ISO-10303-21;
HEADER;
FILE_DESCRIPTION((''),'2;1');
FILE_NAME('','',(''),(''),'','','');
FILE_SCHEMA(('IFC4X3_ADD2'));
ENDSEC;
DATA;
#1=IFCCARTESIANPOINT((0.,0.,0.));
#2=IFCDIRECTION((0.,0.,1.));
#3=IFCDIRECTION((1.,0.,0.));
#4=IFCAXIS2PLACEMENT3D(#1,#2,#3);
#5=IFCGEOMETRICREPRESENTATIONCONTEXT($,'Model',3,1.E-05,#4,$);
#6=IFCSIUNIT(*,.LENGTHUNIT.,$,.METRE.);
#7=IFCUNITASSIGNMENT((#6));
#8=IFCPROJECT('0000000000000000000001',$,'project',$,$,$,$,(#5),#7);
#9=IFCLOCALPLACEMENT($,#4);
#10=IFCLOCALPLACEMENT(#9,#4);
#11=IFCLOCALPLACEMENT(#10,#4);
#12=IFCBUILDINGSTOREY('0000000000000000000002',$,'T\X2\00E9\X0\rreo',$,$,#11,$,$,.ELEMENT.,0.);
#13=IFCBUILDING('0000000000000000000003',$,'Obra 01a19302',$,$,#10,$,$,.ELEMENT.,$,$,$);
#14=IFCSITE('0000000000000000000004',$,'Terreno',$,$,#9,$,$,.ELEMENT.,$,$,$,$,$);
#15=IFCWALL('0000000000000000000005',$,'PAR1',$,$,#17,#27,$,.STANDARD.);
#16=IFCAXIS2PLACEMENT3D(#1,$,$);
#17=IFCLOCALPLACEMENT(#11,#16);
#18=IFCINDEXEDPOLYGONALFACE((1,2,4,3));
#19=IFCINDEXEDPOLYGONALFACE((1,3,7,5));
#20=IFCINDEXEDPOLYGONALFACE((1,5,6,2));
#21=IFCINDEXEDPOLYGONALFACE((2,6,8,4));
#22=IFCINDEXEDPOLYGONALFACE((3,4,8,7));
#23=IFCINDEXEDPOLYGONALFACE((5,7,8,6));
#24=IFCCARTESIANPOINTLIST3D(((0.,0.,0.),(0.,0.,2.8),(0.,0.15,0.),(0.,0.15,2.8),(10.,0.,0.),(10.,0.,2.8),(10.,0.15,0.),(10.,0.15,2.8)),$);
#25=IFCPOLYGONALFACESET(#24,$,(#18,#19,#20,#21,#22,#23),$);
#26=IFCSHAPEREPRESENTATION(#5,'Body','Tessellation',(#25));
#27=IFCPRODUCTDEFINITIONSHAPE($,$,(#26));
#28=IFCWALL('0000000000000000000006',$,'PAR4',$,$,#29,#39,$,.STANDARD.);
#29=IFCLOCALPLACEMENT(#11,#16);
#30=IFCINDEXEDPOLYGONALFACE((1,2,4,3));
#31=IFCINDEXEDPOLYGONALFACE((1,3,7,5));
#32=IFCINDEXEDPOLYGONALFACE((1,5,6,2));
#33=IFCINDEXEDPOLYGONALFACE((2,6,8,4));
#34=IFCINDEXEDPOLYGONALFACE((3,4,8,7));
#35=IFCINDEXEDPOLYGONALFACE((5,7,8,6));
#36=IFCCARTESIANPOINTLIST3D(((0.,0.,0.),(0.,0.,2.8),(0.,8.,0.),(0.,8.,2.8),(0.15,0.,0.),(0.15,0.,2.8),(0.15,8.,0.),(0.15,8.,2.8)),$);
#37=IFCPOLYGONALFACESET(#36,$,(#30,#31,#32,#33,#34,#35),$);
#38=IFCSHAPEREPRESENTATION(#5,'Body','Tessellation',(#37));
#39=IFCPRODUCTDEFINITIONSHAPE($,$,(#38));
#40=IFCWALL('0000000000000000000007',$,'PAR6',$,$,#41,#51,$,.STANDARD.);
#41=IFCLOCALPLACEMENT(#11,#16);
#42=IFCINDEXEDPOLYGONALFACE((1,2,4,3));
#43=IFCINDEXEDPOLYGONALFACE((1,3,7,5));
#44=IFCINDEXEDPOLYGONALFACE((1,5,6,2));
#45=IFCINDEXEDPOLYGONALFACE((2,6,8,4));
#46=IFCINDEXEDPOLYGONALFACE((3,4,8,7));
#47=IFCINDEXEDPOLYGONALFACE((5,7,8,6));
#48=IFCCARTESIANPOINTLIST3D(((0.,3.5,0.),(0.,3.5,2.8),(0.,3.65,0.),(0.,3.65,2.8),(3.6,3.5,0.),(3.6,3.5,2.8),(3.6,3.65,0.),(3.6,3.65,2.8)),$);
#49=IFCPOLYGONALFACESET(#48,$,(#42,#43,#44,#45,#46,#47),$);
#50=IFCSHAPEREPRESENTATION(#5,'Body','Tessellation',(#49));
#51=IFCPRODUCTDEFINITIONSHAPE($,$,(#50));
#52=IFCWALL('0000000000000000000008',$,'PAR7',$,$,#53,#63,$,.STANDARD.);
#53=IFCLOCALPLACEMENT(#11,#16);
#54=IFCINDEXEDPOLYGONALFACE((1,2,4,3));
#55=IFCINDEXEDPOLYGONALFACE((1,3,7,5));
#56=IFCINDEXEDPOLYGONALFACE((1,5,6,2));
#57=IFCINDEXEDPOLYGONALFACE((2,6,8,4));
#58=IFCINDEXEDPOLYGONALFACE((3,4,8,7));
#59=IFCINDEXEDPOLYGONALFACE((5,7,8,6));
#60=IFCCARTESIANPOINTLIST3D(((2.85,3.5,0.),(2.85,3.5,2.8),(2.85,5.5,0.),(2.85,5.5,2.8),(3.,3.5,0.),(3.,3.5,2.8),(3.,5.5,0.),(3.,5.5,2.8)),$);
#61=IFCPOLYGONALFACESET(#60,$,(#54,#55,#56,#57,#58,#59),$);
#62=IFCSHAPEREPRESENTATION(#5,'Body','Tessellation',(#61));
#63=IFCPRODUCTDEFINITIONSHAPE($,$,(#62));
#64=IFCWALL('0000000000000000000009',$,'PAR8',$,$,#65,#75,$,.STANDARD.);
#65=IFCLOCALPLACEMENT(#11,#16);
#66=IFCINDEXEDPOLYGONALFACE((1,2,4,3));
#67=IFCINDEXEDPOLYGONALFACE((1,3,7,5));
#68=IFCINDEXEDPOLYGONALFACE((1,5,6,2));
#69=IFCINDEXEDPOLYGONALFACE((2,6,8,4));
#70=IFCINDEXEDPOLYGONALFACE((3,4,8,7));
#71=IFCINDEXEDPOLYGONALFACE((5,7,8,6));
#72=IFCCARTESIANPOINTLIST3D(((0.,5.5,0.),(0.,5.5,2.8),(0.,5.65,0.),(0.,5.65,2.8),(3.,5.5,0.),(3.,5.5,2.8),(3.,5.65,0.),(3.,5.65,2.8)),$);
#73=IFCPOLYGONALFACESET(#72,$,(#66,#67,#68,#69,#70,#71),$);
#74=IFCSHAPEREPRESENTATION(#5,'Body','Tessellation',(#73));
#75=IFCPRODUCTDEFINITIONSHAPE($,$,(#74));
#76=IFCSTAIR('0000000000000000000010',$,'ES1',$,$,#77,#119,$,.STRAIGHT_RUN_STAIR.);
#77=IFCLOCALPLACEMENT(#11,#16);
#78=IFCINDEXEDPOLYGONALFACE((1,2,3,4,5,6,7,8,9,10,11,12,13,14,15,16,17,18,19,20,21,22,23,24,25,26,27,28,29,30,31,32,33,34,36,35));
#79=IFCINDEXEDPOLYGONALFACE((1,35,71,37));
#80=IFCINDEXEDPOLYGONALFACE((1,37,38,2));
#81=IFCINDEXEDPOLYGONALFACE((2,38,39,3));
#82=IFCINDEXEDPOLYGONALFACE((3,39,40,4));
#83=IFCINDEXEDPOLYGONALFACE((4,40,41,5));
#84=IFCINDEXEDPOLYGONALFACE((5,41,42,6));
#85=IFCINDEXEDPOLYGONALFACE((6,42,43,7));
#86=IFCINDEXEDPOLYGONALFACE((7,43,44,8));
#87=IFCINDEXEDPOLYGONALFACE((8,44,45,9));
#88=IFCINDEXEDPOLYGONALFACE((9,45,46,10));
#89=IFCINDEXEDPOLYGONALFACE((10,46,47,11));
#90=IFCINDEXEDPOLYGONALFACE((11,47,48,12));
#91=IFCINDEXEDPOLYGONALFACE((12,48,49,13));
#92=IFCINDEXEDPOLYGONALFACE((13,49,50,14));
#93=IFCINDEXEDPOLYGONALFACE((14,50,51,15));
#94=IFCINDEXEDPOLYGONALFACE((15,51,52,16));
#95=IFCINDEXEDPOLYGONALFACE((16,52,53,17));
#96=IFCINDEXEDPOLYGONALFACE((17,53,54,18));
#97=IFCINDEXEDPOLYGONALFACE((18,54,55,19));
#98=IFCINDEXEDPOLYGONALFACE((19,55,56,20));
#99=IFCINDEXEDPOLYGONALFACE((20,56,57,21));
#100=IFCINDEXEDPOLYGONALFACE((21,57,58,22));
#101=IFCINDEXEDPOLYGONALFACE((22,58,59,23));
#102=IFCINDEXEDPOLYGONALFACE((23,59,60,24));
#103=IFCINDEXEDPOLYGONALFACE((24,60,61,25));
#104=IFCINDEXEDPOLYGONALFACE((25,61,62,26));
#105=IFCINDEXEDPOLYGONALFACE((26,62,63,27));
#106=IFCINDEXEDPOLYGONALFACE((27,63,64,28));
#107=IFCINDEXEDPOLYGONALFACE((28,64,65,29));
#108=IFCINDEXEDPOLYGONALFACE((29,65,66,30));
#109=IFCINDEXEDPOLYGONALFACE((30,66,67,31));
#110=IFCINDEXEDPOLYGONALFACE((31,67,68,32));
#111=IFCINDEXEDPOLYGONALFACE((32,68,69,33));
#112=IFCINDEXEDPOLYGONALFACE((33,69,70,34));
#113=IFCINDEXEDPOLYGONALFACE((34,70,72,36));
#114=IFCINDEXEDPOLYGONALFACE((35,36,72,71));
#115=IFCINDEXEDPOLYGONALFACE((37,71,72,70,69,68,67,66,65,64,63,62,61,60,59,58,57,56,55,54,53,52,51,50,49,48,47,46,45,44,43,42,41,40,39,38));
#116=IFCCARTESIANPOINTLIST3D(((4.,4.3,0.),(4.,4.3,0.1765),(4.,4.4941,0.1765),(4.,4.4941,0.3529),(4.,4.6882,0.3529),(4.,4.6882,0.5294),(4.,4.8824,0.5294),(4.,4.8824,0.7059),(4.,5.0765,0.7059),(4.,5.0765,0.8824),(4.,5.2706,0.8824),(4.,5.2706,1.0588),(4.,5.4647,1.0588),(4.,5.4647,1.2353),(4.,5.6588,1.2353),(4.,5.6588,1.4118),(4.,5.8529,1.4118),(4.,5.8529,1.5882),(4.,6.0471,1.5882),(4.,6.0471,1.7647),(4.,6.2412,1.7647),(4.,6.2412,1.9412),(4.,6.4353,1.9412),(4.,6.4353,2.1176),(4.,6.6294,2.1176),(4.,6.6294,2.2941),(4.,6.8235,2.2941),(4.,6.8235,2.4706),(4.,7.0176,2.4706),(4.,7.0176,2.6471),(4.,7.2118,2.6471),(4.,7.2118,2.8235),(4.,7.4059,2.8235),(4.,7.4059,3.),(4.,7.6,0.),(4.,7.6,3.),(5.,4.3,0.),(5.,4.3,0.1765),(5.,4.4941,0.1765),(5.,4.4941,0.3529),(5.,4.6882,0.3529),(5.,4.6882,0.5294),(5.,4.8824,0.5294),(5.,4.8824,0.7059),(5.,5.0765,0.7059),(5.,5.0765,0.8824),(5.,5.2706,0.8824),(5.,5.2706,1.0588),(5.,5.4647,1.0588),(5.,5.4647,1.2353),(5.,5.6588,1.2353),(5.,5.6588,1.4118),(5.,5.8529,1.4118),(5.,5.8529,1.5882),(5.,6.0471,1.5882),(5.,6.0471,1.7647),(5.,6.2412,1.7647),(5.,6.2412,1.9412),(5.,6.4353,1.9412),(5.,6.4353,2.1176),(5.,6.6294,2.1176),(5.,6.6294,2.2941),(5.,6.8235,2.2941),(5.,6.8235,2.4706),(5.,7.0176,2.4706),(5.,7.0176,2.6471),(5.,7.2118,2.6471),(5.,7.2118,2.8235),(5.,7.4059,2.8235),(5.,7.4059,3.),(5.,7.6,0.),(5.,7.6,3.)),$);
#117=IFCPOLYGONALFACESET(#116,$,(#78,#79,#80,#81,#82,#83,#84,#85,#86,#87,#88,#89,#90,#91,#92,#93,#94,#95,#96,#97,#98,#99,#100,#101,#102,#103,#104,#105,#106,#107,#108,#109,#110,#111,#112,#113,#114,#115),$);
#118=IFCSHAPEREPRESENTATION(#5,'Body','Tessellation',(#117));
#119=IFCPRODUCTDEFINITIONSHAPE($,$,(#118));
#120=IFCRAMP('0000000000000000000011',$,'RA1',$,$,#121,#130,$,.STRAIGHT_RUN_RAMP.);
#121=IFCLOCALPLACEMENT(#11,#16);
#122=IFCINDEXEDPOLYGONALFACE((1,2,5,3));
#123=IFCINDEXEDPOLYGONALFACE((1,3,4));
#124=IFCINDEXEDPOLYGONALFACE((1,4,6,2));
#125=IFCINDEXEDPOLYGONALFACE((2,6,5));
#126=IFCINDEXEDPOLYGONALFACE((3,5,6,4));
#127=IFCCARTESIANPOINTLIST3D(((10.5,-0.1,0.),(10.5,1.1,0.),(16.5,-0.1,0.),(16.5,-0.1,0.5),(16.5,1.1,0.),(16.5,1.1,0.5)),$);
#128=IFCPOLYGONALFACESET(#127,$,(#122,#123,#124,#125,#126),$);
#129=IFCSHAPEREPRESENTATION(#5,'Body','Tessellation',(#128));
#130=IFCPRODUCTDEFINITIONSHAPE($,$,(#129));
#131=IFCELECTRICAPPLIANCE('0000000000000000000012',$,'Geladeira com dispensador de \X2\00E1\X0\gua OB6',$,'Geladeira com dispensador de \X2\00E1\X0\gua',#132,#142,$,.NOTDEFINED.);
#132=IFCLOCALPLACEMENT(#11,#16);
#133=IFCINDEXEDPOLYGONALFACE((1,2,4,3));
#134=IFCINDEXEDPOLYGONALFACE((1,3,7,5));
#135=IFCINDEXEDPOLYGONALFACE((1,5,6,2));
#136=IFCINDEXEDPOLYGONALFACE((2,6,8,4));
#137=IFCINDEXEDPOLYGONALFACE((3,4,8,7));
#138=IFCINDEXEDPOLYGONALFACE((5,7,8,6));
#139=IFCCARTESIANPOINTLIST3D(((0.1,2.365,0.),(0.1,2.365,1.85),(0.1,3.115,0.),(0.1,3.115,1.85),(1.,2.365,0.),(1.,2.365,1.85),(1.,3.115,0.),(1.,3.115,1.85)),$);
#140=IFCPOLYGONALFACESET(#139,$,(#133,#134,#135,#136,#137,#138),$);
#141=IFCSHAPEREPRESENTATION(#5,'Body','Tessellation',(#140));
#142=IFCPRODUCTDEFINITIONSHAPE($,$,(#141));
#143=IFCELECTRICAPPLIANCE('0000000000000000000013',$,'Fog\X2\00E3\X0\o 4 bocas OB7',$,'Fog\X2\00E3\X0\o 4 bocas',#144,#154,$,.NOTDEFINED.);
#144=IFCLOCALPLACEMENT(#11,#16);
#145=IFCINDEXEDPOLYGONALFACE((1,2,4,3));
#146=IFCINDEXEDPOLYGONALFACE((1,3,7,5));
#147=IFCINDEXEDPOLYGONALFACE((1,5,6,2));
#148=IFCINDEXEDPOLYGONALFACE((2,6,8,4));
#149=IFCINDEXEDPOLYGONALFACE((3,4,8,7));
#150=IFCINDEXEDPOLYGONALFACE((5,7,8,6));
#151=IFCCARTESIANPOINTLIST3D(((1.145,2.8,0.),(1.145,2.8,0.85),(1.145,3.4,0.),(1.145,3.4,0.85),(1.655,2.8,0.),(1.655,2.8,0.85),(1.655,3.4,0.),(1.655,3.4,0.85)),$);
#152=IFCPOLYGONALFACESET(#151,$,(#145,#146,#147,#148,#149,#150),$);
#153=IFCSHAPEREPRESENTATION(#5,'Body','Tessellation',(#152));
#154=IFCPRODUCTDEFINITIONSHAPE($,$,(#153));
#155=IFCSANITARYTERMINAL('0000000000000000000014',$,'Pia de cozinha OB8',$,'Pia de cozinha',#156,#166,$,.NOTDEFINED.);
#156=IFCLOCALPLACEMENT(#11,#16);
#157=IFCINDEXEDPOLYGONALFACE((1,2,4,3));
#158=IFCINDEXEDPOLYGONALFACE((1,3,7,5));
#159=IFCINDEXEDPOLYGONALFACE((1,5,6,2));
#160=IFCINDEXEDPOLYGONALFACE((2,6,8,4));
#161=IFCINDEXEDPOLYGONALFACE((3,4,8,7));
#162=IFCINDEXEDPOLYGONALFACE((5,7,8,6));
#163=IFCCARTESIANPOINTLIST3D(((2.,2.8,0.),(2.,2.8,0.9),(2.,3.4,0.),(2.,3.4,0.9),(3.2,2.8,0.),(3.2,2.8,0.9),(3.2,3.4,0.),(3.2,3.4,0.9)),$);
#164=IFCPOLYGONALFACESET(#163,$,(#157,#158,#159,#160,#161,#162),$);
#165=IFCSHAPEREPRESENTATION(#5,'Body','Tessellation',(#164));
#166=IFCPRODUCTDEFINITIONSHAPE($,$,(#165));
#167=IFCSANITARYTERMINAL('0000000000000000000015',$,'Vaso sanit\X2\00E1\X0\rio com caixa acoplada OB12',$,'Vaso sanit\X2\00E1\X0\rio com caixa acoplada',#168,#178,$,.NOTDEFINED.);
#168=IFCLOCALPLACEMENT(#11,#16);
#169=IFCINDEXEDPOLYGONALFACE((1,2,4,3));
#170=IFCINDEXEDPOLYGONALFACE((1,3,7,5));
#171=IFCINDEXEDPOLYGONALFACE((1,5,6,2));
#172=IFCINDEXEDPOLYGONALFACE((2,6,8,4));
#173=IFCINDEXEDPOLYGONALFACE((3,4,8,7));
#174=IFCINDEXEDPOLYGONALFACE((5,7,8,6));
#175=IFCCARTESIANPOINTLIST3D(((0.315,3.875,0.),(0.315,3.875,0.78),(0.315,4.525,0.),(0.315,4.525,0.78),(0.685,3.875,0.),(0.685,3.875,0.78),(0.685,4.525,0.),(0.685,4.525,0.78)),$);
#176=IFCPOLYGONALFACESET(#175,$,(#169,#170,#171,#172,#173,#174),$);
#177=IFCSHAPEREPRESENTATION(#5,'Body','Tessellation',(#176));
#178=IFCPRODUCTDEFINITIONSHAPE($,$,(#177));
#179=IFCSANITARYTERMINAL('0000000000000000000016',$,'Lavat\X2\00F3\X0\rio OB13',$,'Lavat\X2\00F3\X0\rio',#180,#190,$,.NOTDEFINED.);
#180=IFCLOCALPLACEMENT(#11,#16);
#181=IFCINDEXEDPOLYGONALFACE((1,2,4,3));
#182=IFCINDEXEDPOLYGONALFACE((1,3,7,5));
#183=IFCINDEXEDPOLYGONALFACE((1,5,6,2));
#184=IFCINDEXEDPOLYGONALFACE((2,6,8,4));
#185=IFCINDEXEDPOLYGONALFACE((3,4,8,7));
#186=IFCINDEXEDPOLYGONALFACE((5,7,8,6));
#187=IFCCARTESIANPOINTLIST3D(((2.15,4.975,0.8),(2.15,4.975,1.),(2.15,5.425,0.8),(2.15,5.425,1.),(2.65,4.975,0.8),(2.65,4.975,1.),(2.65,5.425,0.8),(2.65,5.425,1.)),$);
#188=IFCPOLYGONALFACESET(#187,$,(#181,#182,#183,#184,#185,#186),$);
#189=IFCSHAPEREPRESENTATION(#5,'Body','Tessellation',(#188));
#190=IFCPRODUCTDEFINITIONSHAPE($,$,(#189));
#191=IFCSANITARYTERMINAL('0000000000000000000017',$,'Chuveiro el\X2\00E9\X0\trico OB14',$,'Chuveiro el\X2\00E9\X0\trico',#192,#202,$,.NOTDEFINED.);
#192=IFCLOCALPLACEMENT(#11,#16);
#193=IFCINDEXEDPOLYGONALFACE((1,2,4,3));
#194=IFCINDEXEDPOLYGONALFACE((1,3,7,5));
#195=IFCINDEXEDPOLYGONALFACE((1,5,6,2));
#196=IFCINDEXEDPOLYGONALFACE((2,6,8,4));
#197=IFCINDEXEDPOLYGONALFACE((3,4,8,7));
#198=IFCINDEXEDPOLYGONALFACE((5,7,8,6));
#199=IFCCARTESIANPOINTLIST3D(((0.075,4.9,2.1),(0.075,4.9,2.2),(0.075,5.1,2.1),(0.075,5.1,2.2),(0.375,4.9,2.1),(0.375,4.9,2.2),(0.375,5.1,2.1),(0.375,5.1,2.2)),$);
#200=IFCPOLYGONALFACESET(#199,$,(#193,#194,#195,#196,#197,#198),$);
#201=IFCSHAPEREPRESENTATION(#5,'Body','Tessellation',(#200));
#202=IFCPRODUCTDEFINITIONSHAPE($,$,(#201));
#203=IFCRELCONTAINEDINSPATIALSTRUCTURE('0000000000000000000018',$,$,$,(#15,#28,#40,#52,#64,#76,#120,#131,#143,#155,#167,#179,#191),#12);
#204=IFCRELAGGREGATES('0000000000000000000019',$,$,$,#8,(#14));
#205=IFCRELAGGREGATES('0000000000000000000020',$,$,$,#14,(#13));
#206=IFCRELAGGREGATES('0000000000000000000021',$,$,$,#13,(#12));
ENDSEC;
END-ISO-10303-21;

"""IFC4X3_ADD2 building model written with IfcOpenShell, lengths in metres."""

from ifc_helpers import new_model, si_unit, frame, frame_2d, origin_with_axes, place, context, project, spatial, polyline, rectangle, outline, extrude, element, save


model = new_model("IFC4X3_ADD2")

# Units and contexts
model_context = context("Model", 3, precision=1e-05, world=origin_with_axes())
ifc_project = project(units=[si_unit("LENGTHUNIT", "METRE")], contexts=[model_context])

# Site, building, storey
site_placement = place(None, origin_with_axes())
site = spatial("IfcSite", under=ifc_project, at=site_placement, Name="Terreno", CompositionType="ELEMENT")
building_placement = place(site_placement, origin_with_axes())
building = spatial("IfcBuilding", under=site, at=building_placement, Name="Obra 01a19302", CompositionType="ELEMENT")
storey_placement = place(building_placement, origin_with_axes())
storey = spatial("IfcBuildingStorey", under=building, at=storey_placement, Name="Térreo", CompositionType="ELEMENT", Elevation=0.0)

# Walls
wall_1_placement = place(storey_placement, origin_with_axes())
element("IfcWall", 1, at=wall_1_placement, inside=storey, Name="PAR1", PredefinedType="STANDARD", context=model_context, shape_type="SweptSolid", body=[
    extrude(rectangle(XDim=10.0, YDim=0.15, at=frame_2d((5.0, 0.075))), origin_with_axes(), (0.0, 0.0, 1.0), 2.8),
])
wall_2_placement = place(storey_placement, frame((0.0, 8.0, 0.0), z_axis=(0.0, 0.0, 1.0), x_axis=(0.0, -1.0, 0.0)))
element("IfcWall", 2, at=wall_2_placement, inside=storey, Name="PAR4", PredefinedType="STANDARD", context=model_context, shape_type="SweptSolid", body=[
    extrude(rectangle(XDim=8.0, YDim=0.15, at=frame_2d((4.0, 0.075))), origin_with_axes(), (0.0, 0.0, 1.0), 2.8),
])
wall_3_placement = place(storey_placement, frame((0.0, 3.5, 0.0), z_axis=(0.0, 0.0, 1.0), x_axis=(1.0, 0.0, 0.0)))
element("IfcWall", 3, at=wall_3_placement, inside=storey, Name="PAR6", PredefinedType="STANDARD", context=model_context, shape_type="SweptSolid", body=[
    extrude(rectangle(XDim=3.6, YDim=0.15, at=frame_2d((1.8, 0.075))), origin_with_axes(), (0.0, 0.0, 1.0), 2.8),
])
wall_4_placement = place(storey_placement, frame((3.0, 3.5, 0.0), z_axis=(0.0, 0.0, 1.0), x_axis=(0.0, 1.0, 0.0)))
element("IfcWall", 4, at=wall_4_placement, inside=storey, Name="PAR7", PredefinedType="STANDARD", context=model_context, shape_type="SweptSolid", body=[
    extrude(rectangle(XDim=2.0, YDim=0.15, at=frame_2d((1.0, 0.075))), origin_with_axes(), (0.0, 0.0, 1.0), 2.8),
])
wall_5_placement = place(storey_placement, frame((0.0, 5.5, 0.0), z_axis=(0.0, 0.0, 1.0), x_axis=(1.0, 0.0, 0.0)))
element("IfcWall", 5, at=wall_5_placement, inside=storey, Name="PAR8", PredefinedType="STANDARD", context=model_context, shape_type="SweptSolid", body=[
    extrude(rectangle(XDim=3.0, YDim=0.15, at=frame_2d((1.5, 0.075))), origin_with_axes(), (0.0, 0.0, 1.0), 2.8),
])

# Stair
stair_placement = place(storey_placement, origin_with_axes())
element("IfcStair", 6, at=stair_placement, inside=storey, Name="ES1", PredefinedType="STRAIGHT_RUN_STAIR", context=model_context, shape_type="SweptSolid", body=[
    extrude(outline(polyline([(0.0, 0.0), (0.0, 0.1765), (0.1941, 0.1765), (0.1941, 0.3529), (0.3882, 0.3529), (0.3882, 0.5294), (0.5824, 0.5294), (0.5824, 0.7059), (0.7765, 0.7059), (0.7765, 0.8824), (0.9706, 0.8824), (0.9706, 1.0588), (1.1647, 1.0588), (1.1647, 1.2353), (1.3588, 1.2353), (1.3588, 1.4118), (1.5529, 1.4118), (1.5529, 1.5882), (1.7471, 1.5882), (1.7471, 1.7647), (1.9412, 1.7647), (1.9412, 1.9412), (2.1353, 1.9412), (2.1353, 2.1176), (2.3294, 2.1176), (2.3294, 2.2941), (2.5235, 2.2941), (2.5235, 2.4706), (2.7176, 2.4706), (2.7176, 2.6471), (2.9118, 2.6471), (2.9118, 2.8235), (3.1059, 2.8235), (3.1059, 3.0), (3.3, 3.0), (3.3, 0.0), (0.0, 0.0)])), frame((4.0, 4.3, 0.0), z_axis=(1.0, 0.0, 0.0), x_axis=(0.0, 1.0, 0.0)), (0.0, 0.0, 1.0), 1.0),
])

# Ramp
ramp_placement = place(storey_placement, origin_with_axes())
element("IfcRamp", 7, at=ramp_placement, inside=storey, Name="RA1", PredefinedType="STRAIGHT_RUN_RAMP", context=model_context, shape_type="SweptSolid", body=[
    extrude(outline(polyline([(0.0, 0.0), (6.0, 0.5), (6.0, 0.0), (0.0, 0.0)])), frame((10.5, 1.1, 0.0), z_axis=(0.0, -1.0, 0.0), x_axis=(1.0, 0.0, 0.0)), (0.0, 0.0, 1.0), 1.2),
])

# Electric appliances
electric_appliance_1_placement = place(storey_placement, frame((0.1, 2.365, 0.0), z_axis=(0.0, 0.0, 1.0), x_axis=(1.0, 0.0, 0.0)))
element("IfcElectricAppliance", 8, at=electric_appliance_1_placement, inside=storey, Name="Geladeira com dispensador de água OB6", ObjectType="Geladeira com dispensador de água", PredefinedType="NOTDEFINED", context=model_context, shape_type="SweptSolid", body=[
    extrude(rectangle(XDim=0.9, YDim=0.75, at=frame_2d((0.45, 0.375))), origin_with_axes(), (0.0, 0.0, 1.0), 1.85),
])
electric_appliance_2_placement = place(storey_placement, frame((1.145, 2.8, 0.0), z_axis=(0.0, 0.0, 1.0), x_axis=(1.0, 0.0, 0.0)))
element("IfcElectricAppliance", 9, at=electric_appliance_2_placement, inside=storey, Name="Fogão 4 bocas OB7", ObjectType="Fogão 4 bocas", PredefinedType="NOTDEFINED", context=model_context, shape_type="SweptSolid", body=[
    extrude(rectangle(XDim=0.51, YDim=0.6, at=frame_2d((0.255, 0.3))), origin_with_axes(), (0.0, 0.0, 1.0), 0.85),
])

# Sanitary terminals
sanitary_terminal_1_placement = place(storey_placement, frame((2.0, 2.8, 0.0), z_axis=(0.0, 0.0, 1.0), x_axis=(1.0, 0.0, 0.0)))
element("IfcSanitaryTerminal", 10, at=sanitary_terminal_1_placement, inside=storey, Name="Pia de cozinha OB8", ObjectType="Pia de cozinha", PredefinedType="NOTDEFINED", context=model_context, shape_type="SweptSolid", body=[
    extrude(rectangle(XDim=1.2, YDim=0.6, at=frame_2d((0.6, 0.3))), origin_with_axes(), (0.0, 0.0, 1.0), 0.9),
])
sanitary_terminal_2_placement = place(storey_placement, frame((0.315, 3.875, 0.0), z_axis=(0.0, 0.0, 1.0), x_axis=(1.0, 0.0, 0.0)))
element("IfcSanitaryTerminal", 11, at=sanitary_terminal_2_placement, inside=storey, Name="Vaso sanitário com caixa acoplada OB12", ObjectType="Vaso sanitário com caixa acoplada", PredefinedType="NOTDEFINED", context=model_context, shape_type="SweptSolid", body=[
    extrude(rectangle(XDim=0.37, YDim=0.65, at=frame_2d((0.185, 0.325))), origin_with_axes(), (0.0, 0.0, 1.0), 0.78),
])
sanitary_terminal_3_placement = place(storey_placement, frame((2.65, 5.425, 0.8), z_axis=(0.0, 0.0, 1.0), x_axis=(-1.0, 0.0, 0.0)))
element("IfcSanitaryTerminal", 12, at=sanitary_terminal_3_placement, inside=storey, Name="Lavatório OB13", ObjectType="Lavatório", PredefinedType="NOTDEFINED", context=model_context, shape_type="SweptSolid", body=[
    extrude(rectangle(XDim=0.5, YDim=0.45, at=frame_2d((0.25, 0.225))), origin_with_axes(), (0.0, 0.0, 1.0), 0.2),
])
sanitary_terminal_4_placement = place(storey_placement, frame((0.075, 5.1, 2.1), z_axis=(0.0, 0.0, 1.0), x_axis=(0.0, -1.0, 0.0)))
element("IfcSanitaryTerminal", 13, at=sanitary_terminal_4_placement, inside=storey, Name="Chuveiro elétrico OB14", ObjectType="Chuveiro elétrico", PredefinedType="NOTDEFINED", context=model_context, shape_type="SweptSolid", body=[
    extrude(rectangle(XDim=0.2, YDim=0.3, at=frame_2d((0.1, 0.15))), origin_with_axes(), (0.0, 0.0, 1.0), 0.1),
])

save(model, "model.ifc")
